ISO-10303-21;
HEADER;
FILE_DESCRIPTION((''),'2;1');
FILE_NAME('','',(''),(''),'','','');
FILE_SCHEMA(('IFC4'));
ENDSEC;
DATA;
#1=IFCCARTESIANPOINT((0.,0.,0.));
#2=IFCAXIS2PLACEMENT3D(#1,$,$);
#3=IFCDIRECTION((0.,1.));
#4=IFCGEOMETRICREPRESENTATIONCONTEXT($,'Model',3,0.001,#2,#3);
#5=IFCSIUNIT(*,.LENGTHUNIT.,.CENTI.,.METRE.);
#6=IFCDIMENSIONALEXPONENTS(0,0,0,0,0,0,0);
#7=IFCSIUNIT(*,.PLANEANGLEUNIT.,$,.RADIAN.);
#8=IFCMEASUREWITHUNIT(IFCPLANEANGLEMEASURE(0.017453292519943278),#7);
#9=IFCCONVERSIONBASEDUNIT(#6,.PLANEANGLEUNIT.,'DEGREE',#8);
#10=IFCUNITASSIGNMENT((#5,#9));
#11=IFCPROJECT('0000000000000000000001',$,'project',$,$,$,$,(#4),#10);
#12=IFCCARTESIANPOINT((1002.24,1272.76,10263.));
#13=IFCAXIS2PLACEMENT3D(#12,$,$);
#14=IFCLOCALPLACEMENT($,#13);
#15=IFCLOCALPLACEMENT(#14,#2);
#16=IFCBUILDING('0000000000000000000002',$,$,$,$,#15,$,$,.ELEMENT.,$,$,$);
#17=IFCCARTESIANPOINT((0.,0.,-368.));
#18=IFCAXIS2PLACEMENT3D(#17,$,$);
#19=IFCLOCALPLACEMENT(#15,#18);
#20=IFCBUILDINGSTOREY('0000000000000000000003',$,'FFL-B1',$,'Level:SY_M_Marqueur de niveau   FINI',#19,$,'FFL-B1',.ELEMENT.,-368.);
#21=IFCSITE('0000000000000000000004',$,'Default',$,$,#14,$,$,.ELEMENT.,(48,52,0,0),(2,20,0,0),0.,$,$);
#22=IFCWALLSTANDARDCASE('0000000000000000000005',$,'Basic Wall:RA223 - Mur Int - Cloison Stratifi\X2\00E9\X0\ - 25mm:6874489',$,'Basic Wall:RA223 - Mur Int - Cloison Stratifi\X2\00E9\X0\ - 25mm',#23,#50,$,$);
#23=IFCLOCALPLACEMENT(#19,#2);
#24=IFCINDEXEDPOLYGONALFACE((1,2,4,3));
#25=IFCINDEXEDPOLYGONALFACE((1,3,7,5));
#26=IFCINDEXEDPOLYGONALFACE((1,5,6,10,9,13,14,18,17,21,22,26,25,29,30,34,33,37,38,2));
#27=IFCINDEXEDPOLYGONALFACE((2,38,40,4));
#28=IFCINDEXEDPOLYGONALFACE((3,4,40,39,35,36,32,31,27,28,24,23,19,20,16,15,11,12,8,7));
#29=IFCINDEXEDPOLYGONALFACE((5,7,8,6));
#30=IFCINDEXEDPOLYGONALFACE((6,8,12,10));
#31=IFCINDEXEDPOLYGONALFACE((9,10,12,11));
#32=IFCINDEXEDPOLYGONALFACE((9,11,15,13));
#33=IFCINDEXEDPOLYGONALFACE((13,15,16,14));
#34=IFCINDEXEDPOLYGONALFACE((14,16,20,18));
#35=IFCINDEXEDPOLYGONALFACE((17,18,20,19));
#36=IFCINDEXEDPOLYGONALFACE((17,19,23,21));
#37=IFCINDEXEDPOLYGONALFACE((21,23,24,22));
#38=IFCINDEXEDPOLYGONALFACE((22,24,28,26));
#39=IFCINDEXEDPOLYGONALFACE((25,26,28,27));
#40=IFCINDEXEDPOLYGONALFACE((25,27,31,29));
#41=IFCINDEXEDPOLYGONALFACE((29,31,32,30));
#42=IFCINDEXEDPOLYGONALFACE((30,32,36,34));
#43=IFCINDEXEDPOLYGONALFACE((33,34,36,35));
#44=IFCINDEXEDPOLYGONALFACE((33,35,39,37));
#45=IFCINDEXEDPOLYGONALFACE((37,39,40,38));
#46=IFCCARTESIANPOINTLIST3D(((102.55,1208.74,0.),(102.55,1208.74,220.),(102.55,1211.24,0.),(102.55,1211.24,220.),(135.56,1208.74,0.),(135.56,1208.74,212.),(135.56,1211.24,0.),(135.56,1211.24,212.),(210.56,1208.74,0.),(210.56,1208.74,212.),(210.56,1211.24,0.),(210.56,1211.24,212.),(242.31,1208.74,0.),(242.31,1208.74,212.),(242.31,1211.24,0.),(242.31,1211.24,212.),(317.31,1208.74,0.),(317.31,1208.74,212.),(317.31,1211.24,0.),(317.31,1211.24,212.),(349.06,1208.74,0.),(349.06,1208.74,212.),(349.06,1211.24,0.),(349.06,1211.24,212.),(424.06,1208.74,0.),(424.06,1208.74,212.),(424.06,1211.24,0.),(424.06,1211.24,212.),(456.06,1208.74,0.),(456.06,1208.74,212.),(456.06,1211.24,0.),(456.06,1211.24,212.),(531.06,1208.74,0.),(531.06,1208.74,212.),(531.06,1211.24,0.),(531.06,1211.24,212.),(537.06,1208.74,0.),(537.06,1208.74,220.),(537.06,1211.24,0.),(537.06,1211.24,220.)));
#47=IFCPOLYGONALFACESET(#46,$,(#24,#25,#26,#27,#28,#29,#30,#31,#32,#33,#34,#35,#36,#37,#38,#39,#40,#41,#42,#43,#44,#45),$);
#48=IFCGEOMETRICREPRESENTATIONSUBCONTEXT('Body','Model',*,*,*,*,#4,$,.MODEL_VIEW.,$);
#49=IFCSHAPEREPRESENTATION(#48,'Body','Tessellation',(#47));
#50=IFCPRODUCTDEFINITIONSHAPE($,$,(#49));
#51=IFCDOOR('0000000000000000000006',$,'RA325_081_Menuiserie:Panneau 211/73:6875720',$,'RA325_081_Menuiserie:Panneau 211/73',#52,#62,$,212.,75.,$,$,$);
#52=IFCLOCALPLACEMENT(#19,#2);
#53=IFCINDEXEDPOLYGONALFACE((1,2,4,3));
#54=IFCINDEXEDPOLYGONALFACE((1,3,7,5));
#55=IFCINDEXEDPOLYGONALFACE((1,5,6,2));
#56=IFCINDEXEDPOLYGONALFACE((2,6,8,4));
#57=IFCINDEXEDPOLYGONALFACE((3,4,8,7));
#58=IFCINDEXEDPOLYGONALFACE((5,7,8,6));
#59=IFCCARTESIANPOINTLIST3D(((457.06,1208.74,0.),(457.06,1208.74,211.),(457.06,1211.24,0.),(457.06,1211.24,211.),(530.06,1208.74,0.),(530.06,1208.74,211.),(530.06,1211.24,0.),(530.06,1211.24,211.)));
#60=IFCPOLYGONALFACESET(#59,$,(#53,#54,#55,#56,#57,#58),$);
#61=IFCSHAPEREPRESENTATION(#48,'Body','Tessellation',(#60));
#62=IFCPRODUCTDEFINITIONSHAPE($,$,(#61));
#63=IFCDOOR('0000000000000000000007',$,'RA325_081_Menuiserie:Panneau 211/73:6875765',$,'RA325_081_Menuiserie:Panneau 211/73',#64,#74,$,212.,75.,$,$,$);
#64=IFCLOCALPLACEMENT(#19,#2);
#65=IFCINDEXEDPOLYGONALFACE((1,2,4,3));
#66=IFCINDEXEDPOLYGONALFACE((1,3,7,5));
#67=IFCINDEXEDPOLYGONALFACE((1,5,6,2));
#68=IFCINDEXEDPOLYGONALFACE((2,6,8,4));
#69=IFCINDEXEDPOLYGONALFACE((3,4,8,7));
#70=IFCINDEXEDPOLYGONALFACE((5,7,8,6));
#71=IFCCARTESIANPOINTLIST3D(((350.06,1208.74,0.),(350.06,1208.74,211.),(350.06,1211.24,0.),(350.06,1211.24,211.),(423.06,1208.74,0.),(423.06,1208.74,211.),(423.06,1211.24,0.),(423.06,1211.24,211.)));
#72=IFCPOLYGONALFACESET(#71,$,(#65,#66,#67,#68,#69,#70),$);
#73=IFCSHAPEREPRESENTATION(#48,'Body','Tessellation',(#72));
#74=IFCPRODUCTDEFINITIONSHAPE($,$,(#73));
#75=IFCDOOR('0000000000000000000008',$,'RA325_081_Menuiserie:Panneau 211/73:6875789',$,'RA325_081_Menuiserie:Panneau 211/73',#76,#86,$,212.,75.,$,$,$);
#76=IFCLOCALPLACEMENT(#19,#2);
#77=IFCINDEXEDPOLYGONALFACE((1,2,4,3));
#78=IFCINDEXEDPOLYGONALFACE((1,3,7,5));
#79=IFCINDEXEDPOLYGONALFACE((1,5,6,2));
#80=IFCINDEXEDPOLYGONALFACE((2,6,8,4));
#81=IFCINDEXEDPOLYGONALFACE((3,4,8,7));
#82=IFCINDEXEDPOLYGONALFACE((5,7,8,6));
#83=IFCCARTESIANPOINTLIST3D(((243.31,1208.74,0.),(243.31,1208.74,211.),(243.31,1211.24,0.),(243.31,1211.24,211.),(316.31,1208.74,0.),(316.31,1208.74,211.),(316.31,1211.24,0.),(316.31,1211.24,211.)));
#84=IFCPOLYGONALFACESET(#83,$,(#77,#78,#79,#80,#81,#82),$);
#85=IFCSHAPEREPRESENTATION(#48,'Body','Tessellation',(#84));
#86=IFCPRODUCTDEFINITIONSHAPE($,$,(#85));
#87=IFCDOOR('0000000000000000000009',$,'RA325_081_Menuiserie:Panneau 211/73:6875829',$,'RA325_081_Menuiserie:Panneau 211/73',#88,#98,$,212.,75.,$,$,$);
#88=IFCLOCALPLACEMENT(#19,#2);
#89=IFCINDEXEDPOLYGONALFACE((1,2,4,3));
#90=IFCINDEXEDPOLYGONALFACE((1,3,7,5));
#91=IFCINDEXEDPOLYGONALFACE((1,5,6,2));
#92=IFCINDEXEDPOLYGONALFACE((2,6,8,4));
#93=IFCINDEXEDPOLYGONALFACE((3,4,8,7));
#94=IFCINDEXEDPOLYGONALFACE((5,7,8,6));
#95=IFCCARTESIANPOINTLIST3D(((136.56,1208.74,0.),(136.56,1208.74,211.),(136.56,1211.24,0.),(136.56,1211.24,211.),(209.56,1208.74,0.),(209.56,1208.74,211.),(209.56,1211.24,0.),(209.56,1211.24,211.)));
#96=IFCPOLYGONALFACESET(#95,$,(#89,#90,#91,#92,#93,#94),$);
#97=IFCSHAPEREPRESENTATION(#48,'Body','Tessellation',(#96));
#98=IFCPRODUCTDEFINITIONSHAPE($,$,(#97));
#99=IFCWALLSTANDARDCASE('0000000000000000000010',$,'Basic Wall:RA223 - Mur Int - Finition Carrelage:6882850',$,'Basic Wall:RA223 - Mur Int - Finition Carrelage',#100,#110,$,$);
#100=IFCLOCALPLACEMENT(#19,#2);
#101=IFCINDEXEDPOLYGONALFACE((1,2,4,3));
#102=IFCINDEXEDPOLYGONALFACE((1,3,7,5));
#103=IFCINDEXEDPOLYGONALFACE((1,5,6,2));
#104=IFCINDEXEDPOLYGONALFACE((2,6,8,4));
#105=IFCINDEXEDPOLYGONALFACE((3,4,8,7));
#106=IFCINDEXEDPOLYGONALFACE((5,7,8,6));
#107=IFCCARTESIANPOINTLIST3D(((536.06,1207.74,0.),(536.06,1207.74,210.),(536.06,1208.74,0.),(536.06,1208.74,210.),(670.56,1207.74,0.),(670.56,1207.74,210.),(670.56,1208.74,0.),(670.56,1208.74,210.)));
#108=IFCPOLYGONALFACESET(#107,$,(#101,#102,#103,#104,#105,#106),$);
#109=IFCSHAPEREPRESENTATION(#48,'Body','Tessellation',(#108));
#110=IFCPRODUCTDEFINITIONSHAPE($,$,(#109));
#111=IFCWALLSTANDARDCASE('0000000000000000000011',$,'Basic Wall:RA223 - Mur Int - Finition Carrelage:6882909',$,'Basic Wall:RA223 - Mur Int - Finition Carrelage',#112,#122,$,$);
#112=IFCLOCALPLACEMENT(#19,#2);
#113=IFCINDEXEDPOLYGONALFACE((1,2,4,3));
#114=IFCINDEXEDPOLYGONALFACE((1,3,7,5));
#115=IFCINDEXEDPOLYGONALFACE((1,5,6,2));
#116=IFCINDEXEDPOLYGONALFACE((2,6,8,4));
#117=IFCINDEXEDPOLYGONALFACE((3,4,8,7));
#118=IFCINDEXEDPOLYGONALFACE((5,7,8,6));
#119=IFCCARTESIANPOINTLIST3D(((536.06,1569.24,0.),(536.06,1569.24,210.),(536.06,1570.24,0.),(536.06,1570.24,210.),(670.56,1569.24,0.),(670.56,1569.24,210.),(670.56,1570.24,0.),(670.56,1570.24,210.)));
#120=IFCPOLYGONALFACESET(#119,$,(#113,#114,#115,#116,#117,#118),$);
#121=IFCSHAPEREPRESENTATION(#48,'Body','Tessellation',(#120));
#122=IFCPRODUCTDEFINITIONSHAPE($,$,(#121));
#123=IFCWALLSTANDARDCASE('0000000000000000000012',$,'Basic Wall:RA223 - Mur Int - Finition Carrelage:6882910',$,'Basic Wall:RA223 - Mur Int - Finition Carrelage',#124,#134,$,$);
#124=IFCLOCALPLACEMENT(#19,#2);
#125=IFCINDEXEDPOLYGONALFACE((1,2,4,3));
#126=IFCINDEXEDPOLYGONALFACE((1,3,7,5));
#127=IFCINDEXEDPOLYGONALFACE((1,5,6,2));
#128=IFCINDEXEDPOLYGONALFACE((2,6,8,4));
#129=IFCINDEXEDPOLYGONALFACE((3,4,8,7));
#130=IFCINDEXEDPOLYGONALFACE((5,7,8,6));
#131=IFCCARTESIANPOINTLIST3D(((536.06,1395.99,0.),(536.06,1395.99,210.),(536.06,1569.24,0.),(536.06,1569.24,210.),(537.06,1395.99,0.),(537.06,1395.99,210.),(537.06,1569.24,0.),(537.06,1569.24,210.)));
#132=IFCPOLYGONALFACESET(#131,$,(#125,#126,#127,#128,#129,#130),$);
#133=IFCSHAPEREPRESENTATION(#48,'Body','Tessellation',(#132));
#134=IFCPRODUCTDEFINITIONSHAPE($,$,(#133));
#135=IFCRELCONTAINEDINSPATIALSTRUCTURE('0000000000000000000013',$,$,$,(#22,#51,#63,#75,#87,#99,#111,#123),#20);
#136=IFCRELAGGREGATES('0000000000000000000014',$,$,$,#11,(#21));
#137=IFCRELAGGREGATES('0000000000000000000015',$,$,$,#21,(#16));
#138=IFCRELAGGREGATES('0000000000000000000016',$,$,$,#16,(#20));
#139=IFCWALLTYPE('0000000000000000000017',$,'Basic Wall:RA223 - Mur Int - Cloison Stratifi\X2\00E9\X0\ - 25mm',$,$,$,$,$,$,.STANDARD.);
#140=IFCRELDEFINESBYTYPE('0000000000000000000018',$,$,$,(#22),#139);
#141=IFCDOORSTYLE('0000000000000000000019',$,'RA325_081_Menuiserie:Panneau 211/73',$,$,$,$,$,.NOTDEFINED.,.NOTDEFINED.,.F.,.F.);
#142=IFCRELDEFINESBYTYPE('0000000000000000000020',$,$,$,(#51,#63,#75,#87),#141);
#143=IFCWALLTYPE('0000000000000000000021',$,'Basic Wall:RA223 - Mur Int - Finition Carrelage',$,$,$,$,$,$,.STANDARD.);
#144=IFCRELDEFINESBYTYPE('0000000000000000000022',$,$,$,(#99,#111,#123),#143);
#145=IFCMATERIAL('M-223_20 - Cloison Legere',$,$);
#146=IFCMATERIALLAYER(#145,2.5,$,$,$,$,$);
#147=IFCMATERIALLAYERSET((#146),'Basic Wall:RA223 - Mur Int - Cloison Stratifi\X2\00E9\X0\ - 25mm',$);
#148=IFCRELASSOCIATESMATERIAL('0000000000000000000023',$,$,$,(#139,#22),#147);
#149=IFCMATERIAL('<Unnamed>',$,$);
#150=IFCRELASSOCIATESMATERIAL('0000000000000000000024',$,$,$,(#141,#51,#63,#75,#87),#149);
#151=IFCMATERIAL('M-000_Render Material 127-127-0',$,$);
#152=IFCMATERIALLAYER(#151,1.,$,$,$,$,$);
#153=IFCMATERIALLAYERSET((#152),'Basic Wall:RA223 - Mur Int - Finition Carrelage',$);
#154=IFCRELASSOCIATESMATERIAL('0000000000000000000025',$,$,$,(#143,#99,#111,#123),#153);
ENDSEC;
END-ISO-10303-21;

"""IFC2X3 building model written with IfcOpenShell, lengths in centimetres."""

from ifc_helpers import new_model, entity, si_unit, converted_unit, direction, frame, frame_2d, origin, origin_2d_with_axis, place, context, subcontext, project, spatial, rectangle, extrude, source, transform, mapped, material, layer, layer_set, layer_usage, type_object, type_shapes, element, fill, save


model = new_model("IFC2X3")

# Units and contexts
model_context = context("Model", 3, precision=0.001, world=origin(), true_north=direction((0.0, 1.0)))
body_context = subcontext(model_context, "Body", "Model", "MODEL_VIEW")
ifc_project = project(units=[si_unit("LENGTHUNIT", "METRE", prefix="CENTI"), converted_unit("PLANEANGLEUNIT", "DEGREE", entity("IfcPlaneAngleMeasure", 0.017453292519943278), si_unit("PLANEANGLEUNIT", "RADIAN"), dimensions=[0, 0, 0, 0, 0, 0, 0])], contexts=[model_context])

# Site, building, storey
site_placement = place(None, frame((1002.24, 1272.76, 10263.0)))
site = spatial("IfcSite", under=ifc_project, at=site_placement, Name="Default", CompositionType="ELEMENT", RefLatitude=(48, 52, 0, 0), RefLongitude=(2, 20, 0, 0), RefElevation=0.0)
building_placement = place(site_placement, origin())
building = spatial("IfcBuilding", under=site, at=building_placement, CompositionType="ELEMENT")
storey_placement = place(building_placement, frame((0.0, 0.0, -368.0)))
storey = spatial("IfcBuildingStorey", under=building, at=storey_placement, Name="FFL-B1", ObjectType="Level:SY_M_Marqueur de niveau   FINI", LongName="FFL-B1", CompositionType="ELEMENT", Elevation=-368.0)

# Wall, openings, doors
ifc_material_1 = material(Name="M-223_20 - Cloison Legere")
ifc_layer_1 = layer(ifc_material_1, 2.5)
ifc_layer_set_1 = layer_set([ifc_layer_1], Name="Basic Wall:RA223 - Mur Int - Cloison Stratifié - 25mm")
wall_type_1 = type_object("IfcWallType", Name="Basic Wall:RA223 - Mur Int - Cloison Stratifié - 25mm", PredefinedType="STANDARD", material=ifc_layer_set_1)
ifc_material_2 = material(Name="<Unnamed>")
ifc_layer_usage_1 = layer_usage(ifc_layer_set_1, "AXIS2", "NEGATIVE", 1.25)
wall_1_placement = place(storey_placement, frame((537.06, 1209.99, 0.0), z_axis=(0.0, 0.0, 1.0), x_axis=(-1.0, 0.0, 0.0)))
wall_1 = element("IfcWallStandardCase", 1, at=wall_1_placement, inside=storey, type_object=wall_type_1, material=ifc_layer_usage_1, Name="Basic Wall:RA223 - Mur Int - Cloison Stratifié - 25mm:6874489", ObjectType="Basic Wall:RA223 - Mur Int - Cloison Stratifié - 25mm", context=body_context, shape_type="SweptSolid", body=[
    extrude(rectangle(XDim=434.51, YDim=2.5, at=frame_2d((217.25, 0.0), x_axis=(1.0, 0.0))), origin(), (0.0, 0.0, 1.0), 220.0),
])
opening_1_placement = place(wall_1_placement, frame((537.06, 1209.99, 0.0), z_axis=(0.0, 0.0, 1.0), x_axis=(-1.0, 0.0, 0.0)))
opening_1 = element("IfcOpeningElement", 2, at=opening_1_placement, cuts=wall_1, ObjectType="Opening", context=body_context, shape_type="SweptSolid", body=[
    extrude(rectangle(XDim=212.0, YDim=75.0, at=frame_2d((0.0, 0.0), x_axis=(1.0, 0.0))), frame((493.56, 1211.24, 106.0), z_axis=(0.0, -1.0, 0.0), x_axis=(0.0, 0.0, -1.0)), (0.0, 0.0, 1.0), 2.5),
])
opening_2_placement = place(wall_1_placement, frame((537.06, 1209.99, 0.0), z_axis=(0.0, 0.0, 1.0), x_axis=(-1.0, 0.0, 0.0)))
opening_2 = element("IfcOpeningElement", 3, at=opening_2_placement, cuts=wall_1, ObjectType="Opening", context=body_context, shape_type="SweptSolid", body=[
    extrude(rectangle(XDim=212.0, YDim=75.0, at=frame_2d((0.0, 0.0), x_axis=(1.0, 0.0))), frame((386.56, 1211.24, 106.0), z_axis=(0.0, -1.0, 0.0), x_axis=(0.0, 0.0, -1.0)), (0.0, 0.0, 1.0), 2.5),
])
opening_3_placement = place(wall_1_placement, frame((537.06, 1209.99, 0.0), z_axis=(0.0, 0.0, 1.0), x_axis=(-1.0, 0.0, 0.0)))
opening_3 = element("IfcOpeningElement", 4, at=opening_3_placement, cuts=wall_1, ObjectType="Opening", context=body_context, shape_type="SweptSolid", body=[
    extrude(rectangle(XDim=212.0, YDim=75.0, at=frame_2d((0.0, 0.0), x_axis=(1.0, 0.0))), frame((279.81, 1211.24, 106.0), z_axis=(0.0, -1.0, 0.0), x_axis=(0.0, 0.0, -1.0)), (0.0, 0.0, 1.0), 2.5),
])
opening_4_placement = place(wall_1_placement, frame((537.06, 1209.99, 0.0), z_axis=(0.0, 0.0, 1.0), x_axis=(-1.0, 0.0, 0.0)))
opening_4 = element("IfcOpeningElement", 5, at=opening_4_placement, cuts=wall_1, ObjectType="Opening", context=body_context, shape_type="SweptSolid", body=[
    extrude(rectangle(XDim=212.0, YDim=75.0, at=origin_2d_with_axis()), frame((173.06, 1211.24, 106.0), z_axis=(0.0, -1.0, 0.0), x_axis=(0.0, 0.0, -1.0)), (0.0, 0.0, 1.0), 2.5),
])
door_style_1 = type_object("IfcDoorStyle", Name="RA325_081_Menuiserie:Panneau 211/73", ConstructionType="NOTDEFINED", OperationType="NOTDEFINED", ParameterTakesPrecedence=False, Sizeable=False, material=ifc_material_2)
shared_shape_1 = source(origin(), body_context, "Body", "SweptSolid", [
    extrude(rectangle(XDim=73.0, YDim=2.5, at=frame_2d((0.0, 0.0), x_axis=(1.0, 0.0))), frame((37.5, 1.25, 0.0), z_axis=(0.0, 0.0, 1.0), x_axis=(-1.0, 0.0, 0.0)), (0.0, 0.0, 1.0), 211.0),
])
type_shapes(door_style_1, [shared_shape_1])
door_1_placement = place(opening_1_placement, frame((531.06, 1211.24, 0.0), z_axis=(0.0, 0.0, 1.0), x_axis=(-1.0, 0.0, 0.0)))
door_1 = element("IfcDoor", 6, at=door_1_placement, inside=storey, type_object=door_style_1, material=ifc_material_2, Name="RA325_081_Menuiserie:Panneau 211/73:6875720", ObjectType="RA325_081_Menuiserie:Panneau 211/73", OverallHeight=212.0, OverallWidth=75.0, context=body_context, shape_type="MappedRepresentation", body=[
    mapped(shared_shape_1, transform((0.0, 0.0, 0.0), scale=1.0)),
])
fill(opening_1, door_1)
door_2_placement = place(opening_2_placement, frame((424.06, 1211.24, 0.0), z_axis=(0.0, 0.0, 1.0), x_axis=(-1.0, 0.0, 0.0)))
door_2 = element("IfcDoor", 7, at=door_2_placement, inside=storey, type_object=door_style_1, material=ifc_material_2, Name="RA325_081_Menuiserie:Panneau 211/73:6875765", ObjectType="RA325_081_Menuiserie:Panneau 211/73", OverallHeight=212.0, OverallWidth=75.0, context=body_context, shape_type="MappedRepresentation", body=[
    mapped(shared_shape_1, transform((0.0, 0.0, 0.0), scale=1.0)),
])
fill(opening_2, door_2)
door_3_placement = place(opening_3_placement, frame((317.31, 1211.24, 0.0), z_axis=(0.0, 0.0, 1.0), x_axis=(-1.0, 0.0, 0.0)))
door_3 = element("IfcDoor", 8, at=door_3_placement, inside=storey, type_object=door_style_1, material=ifc_material_2, Name="RA325_081_Menuiserie:Panneau 211/73:6875789", ObjectType="RA325_081_Menuiserie:Panneau 211/73", OverallHeight=212.0, OverallWidth=75.0, context=body_context, shape_type="MappedRepresentation", body=[
    mapped(shared_shape_1, transform((0.0, 0.0, 0.0), scale=1.0)),
])
fill(opening_3, door_3)
door_4_placement = place(opening_4_placement, frame((210.56, 1211.24, 0.0), z_axis=(0.0, 0.0, 1.0), x_axis=(-1.0, 0.0, 0.0)))
door_4 = element("IfcDoor", 9, at=door_4_placement, inside=storey, type_object=door_style_1, material=ifc_material_2, Name="RA325_081_Menuiserie:Panneau 211/73:6875829", ObjectType="RA325_081_Menuiserie:Panneau 211/73", OverallHeight=212.0, OverallWidth=75.0, context=body_context, shape_type="MappedRepresentation", body=[
    mapped(shared_shape_1, transform((0.0, 0.0, 0.0), scale=1.0)),
])
fill(opening_4, door_4)

# Shared definitions
ifc_material_3 = material(Name="M-000_Render Material 127-127-0")
ifc_layer_2 = layer(ifc_material_3, 1.0)
ifc_layer_set_2 = layer_set([ifc_layer_2], Name="Basic Wall:RA223 - Mur Int - Finition Carrelage")
wall_type_2 = type_object("IfcWallType", Name="Basic Wall:RA223 - Mur Int - Finition Carrelage", PredefinedType="STANDARD", material=ifc_layer_set_2)

# Walls
ifc_layer_usage_2 = layer_usage(ifc_layer_set_2, "AXIS2", "NEGATIVE", 0.5)
wall_2_placement = place(storey_placement, frame((670.56, 1208.24, 0.0), z_axis=(0.0, 0.0, 1.0), x_axis=(-1.0, 0.0, 0.0)))
element("IfcWallStandardCase", 10, at=wall_2_placement, inside=storey, type_object=wall_type_2, material=ifc_layer_usage_2, Name="Basic Wall:RA223 - Mur Int - Finition Carrelage:6882850", ObjectType="Basic Wall:RA223 - Mur Int - Finition Carrelage", context=body_context, shape_type="SweptSolid", body=[
    extrude(rectangle(XDim=134.5, YDim=1.0, at=frame_2d((67.25, 0.0), x_axis=(-1.0, 0.0))), origin(), (0.0, 0.0, 1.0), 210.0),
])
ifc_layer_usage_3 = layer_usage(ifc_layer_set_2, "AXIS2", "POSITIVE", -0.5)
wall_3_placement = place(storey_placement, frame((670.56, 1569.74, 0.0), z_axis=(0.0, 0.0, 1.0), x_axis=(-1.0, 0.0, 0.0)))
element("IfcWallStandardCase", 11, at=wall_3_placement, inside=storey, type_object=wall_type_2, material=ifc_layer_usage_3, Name="Basic Wall:RA223 - Mur Int - Finition Carrelage:6882909", ObjectType="Basic Wall:RA223 - Mur Int - Finition Carrelage", context=body_context, shape_type="SweptSolid", body=[
    extrude(rectangle(XDim=134.5, YDim=1.0, at=frame_2d((67.25, 0.0), x_axis=(-1.0, 0.0))), origin(), (0.0, 0.0, 1.0), 210.0),
])
ifc_layer_usage_4 = layer_usage(ifc_layer_set_2, "AXIS2", "POSITIVE", -0.5)
wall_4_placement = place(storey_placement, frame((536.56, 1569.24, 0.0), z_axis=(0.0, 0.0, 1.0), x_axis=(0.0, -1.0, 0.0)))
element("IfcWallStandardCase", 12, at=wall_4_placement, inside=storey, type_object=wall_type_2, material=ifc_layer_usage_4, Name="Basic Wall:RA223 - Mur Int - Finition Carrelage:6882910", ObjectType="Basic Wall:RA223 - Mur Int - Finition Carrelage", context=body_context, shape_type="SweptSolid", body=[
    extrude(rectangle(XDim=173.25, YDim=1.0, at=frame_2d((86.63, 0.0), x_axis=(-1.0, 0.0))), origin(), (0.0, 0.0, 1.0), 210.0),
])

save(model, "model.ifc")
